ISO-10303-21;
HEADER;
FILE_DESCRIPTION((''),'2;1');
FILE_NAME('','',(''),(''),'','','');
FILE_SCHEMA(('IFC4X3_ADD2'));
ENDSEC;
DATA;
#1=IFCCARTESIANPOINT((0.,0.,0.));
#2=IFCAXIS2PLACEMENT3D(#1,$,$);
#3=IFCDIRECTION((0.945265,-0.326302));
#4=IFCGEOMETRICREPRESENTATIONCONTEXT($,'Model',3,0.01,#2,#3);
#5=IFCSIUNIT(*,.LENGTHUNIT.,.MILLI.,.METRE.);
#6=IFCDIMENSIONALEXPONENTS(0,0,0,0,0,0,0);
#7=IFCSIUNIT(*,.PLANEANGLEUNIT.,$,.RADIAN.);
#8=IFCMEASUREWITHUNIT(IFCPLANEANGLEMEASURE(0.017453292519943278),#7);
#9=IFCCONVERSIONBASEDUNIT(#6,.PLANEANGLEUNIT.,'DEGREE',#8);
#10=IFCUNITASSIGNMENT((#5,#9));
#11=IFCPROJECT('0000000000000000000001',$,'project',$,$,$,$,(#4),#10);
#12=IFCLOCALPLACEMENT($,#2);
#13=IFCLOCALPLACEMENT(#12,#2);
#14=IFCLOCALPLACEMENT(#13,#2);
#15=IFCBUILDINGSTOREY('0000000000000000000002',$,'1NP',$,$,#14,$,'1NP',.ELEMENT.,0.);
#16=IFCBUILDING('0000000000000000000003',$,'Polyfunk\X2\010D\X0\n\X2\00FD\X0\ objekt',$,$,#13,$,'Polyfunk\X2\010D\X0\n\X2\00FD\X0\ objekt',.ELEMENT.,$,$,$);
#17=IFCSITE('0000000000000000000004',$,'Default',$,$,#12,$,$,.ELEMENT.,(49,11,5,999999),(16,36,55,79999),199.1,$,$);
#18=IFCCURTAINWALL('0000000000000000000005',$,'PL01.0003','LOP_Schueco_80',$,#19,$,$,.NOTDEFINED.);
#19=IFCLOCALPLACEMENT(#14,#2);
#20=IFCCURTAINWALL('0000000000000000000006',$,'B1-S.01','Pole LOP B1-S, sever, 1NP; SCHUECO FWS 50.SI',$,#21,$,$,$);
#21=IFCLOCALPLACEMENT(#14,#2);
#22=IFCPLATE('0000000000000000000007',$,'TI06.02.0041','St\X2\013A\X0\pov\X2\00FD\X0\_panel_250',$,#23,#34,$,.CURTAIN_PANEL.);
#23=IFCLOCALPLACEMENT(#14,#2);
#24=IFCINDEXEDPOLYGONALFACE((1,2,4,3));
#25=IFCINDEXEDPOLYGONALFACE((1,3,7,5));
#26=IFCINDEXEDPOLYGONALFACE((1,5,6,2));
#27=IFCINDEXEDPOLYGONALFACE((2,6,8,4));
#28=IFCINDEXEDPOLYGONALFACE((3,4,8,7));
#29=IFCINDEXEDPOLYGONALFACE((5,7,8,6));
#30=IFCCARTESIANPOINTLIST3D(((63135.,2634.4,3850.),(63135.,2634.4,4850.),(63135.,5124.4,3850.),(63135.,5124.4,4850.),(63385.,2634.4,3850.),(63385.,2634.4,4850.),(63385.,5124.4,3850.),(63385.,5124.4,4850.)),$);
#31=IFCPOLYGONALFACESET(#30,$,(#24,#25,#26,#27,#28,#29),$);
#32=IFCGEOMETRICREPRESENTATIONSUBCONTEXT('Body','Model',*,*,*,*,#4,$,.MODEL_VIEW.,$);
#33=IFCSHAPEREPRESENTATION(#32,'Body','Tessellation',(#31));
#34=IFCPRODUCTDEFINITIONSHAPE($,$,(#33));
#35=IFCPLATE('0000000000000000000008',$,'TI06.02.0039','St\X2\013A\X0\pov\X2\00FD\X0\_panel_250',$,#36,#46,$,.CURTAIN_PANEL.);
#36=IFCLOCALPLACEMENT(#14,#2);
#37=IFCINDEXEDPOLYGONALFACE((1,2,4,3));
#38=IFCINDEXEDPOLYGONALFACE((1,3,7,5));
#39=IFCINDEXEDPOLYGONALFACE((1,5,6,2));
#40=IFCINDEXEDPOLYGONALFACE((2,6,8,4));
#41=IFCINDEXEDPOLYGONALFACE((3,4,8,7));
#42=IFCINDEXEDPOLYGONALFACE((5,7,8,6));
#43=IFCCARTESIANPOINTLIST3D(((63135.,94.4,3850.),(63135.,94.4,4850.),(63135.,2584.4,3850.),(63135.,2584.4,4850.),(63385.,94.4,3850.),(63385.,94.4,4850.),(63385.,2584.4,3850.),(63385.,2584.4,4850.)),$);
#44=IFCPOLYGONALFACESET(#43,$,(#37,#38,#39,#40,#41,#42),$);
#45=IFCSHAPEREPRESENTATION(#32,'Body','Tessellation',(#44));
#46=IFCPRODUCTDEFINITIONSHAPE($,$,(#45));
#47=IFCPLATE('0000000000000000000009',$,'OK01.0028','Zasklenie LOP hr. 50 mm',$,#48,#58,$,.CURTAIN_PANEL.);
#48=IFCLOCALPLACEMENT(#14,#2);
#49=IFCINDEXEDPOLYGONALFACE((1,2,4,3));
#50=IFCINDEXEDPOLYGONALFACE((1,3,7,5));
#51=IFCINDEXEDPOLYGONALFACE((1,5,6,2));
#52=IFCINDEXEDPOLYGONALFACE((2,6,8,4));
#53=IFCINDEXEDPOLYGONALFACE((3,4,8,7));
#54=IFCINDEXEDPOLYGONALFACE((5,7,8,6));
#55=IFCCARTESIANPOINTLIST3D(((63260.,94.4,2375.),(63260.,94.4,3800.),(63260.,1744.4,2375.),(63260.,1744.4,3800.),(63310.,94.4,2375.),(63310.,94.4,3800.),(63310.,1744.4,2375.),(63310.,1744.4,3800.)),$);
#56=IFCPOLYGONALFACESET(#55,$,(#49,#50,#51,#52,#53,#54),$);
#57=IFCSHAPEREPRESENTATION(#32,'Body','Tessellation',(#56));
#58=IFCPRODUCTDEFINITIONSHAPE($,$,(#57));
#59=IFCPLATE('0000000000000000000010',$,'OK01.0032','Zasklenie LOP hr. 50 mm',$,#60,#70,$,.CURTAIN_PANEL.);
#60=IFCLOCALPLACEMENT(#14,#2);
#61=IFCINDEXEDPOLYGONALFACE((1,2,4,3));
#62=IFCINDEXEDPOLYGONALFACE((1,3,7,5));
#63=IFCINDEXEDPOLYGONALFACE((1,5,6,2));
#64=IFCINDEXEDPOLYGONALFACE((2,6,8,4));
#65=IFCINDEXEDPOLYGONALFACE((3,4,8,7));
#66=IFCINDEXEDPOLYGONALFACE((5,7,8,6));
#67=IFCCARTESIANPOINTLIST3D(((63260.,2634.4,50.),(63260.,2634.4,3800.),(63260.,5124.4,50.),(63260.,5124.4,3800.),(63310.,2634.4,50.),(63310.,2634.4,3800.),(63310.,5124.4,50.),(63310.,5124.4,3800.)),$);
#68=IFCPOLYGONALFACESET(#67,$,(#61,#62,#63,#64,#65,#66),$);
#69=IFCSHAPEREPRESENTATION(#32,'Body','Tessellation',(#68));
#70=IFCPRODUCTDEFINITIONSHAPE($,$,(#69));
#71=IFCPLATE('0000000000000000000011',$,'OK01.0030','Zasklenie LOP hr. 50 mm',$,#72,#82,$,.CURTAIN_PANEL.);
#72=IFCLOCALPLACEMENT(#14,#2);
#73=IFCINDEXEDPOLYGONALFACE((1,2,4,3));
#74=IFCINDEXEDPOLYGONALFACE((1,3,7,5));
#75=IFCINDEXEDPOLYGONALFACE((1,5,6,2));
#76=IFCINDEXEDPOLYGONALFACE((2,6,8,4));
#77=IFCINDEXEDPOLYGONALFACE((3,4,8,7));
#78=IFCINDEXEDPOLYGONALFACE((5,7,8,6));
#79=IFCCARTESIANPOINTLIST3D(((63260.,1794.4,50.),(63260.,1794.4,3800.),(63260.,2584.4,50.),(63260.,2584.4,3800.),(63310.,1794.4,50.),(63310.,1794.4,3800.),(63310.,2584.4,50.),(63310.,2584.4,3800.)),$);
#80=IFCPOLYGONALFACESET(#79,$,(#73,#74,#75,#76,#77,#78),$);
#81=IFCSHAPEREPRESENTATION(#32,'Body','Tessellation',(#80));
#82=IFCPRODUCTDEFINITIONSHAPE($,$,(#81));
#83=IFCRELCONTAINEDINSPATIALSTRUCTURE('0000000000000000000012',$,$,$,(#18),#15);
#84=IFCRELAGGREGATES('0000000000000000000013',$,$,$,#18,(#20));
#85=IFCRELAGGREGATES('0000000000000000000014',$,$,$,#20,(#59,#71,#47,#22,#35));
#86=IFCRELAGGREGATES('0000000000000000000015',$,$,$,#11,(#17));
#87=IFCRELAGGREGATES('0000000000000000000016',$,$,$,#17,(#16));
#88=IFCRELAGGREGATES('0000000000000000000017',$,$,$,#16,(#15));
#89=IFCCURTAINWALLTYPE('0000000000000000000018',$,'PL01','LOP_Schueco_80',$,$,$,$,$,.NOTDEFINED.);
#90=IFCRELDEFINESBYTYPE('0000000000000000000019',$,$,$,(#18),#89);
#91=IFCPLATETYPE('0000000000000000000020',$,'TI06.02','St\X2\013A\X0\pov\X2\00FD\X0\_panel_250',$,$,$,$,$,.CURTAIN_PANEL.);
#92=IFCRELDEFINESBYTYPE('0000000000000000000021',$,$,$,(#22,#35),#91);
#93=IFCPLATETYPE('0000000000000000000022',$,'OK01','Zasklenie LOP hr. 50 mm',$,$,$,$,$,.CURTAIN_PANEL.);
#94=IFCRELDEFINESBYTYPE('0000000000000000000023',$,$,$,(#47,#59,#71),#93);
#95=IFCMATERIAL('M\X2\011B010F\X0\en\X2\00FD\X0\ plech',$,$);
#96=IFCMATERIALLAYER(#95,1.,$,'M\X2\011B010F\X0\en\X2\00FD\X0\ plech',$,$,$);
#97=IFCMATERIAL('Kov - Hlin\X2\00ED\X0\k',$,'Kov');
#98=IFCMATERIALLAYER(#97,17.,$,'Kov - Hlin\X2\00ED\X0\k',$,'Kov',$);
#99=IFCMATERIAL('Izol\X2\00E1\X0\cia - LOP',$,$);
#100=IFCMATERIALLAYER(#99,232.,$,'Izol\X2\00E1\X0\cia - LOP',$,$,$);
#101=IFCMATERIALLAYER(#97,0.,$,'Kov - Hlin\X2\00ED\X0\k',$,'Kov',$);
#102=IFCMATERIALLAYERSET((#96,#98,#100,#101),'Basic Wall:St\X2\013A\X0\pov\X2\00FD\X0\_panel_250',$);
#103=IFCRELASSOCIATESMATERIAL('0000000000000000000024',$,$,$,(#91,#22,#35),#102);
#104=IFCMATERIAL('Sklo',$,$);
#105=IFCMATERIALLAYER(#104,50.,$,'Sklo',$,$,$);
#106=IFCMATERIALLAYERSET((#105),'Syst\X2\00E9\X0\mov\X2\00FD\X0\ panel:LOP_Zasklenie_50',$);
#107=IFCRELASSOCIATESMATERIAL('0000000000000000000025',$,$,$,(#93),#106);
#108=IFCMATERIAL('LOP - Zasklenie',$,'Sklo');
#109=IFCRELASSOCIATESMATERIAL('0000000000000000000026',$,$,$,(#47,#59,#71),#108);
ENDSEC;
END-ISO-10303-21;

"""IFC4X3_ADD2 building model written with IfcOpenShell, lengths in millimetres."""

from ifc_helpers import new_model, entity, si_unit, converted_unit, direction, frame, frame_2d, origin, origin_2d_with_axis, place, context, subcontext, project, spatial, rectangle, extrude, source, transform, mapped, material, layer, layer_set, layer_usage, type_object, type_shapes, element, aggregate, save


model = new_model("IFC4X3_ADD2")

# Units and contexts
model_context = context("Model", 3, precision=0.01, world=origin(), true_north=direction((0.945265, -0.326302)))
body_context = subcontext(model_context, "Body", "Model", "MODEL_VIEW")
ifc_project = project(units=[si_unit("LENGTHUNIT", "METRE", prefix="MILLI"), converted_unit("PLANEANGLEUNIT", "DEGREE", entity("IfcPlaneAngleMeasure", 0.017453292519943278), si_unit("PLANEANGLEUNIT", "RADIAN"), dimensions=[0, 0, 0, 0, 0, 0, 0])], contexts=[model_context])

# Site, building, storey
site_placement = place(None, origin())
site = spatial("IfcSite", under=ifc_project, at=site_placement, Name="Default", CompositionType="ELEMENT", RefLatitude=(49, 11, 5, 999999), RefLongitude=(16, 36, 55, 79999), RefElevation=199.1)
building_placement = place(site_placement, origin())
building = spatial("IfcBuilding", under=site, at=building_placement, Name="Polyfunkčný objekt", LongName="Polyfunkčný objekt", CompositionType="ELEMENT")
storey_placement = place(building_placement, origin())
storey = spatial("IfcBuildingStorey", under=building, at=storey_placement, Name="1NP", LongName="1NP", CompositionType="ELEMENT", Elevation=0.0)

# Curtain walls, plates
curtain_wall_type = type_object("IfcCurtainWallType", Name="PL01", Description="LOP_Schueco_80", PredefinedType="NOTDEFINED")
curtain_wall_1_placement = place(storey_placement, origin())
curtain_wall_1 = element("IfcCurtainWall", 1, at=curtain_wall_1_placement, inside=storey, type_object=curtain_wall_type, Name="PL01.0003", Description="LOP_Schueco_80", PredefinedType="NOTDEFINED")
curtain_wall_2 = element("IfcCurtainWall", 2, Name="B1-S.01", Description="Pole LOP B1-S, sever, 1NP; SCHUECO FWS 50.SI")
aggregate(curtain_wall_1, [curtain_wall_2])
ifc_material_1 = material(Name="Měďený plech")
ifc_layer_1 = layer(ifc_material_1, 1.0, Name="Měďený plech")
ifc_material_2 = material(Name="Kov - Hliník", Category="Kov")
ifc_layer_2 = layer(ifc_material_2, 17.0, Name="Kov - Hliník", Category="Kov")
ifc_material_3 = material(Name="Izolácia - LOP")
ifc_layer_3 = layer(ifc_material_3, 232.0, Name="Izolácia - LOP")
ifc_layer_4 = layer(ifc_material_2, 0.0, Name="Kov - Hliník", Category="Kov")
ifc_layer_set_1 = layer_set([ifc_layer_1, ifc_layer_2, ifc_layer_3, ifc_layer_4], Name="Basic Wall:Stĺpový_panel_250")
ifc_layer_usage_1 = layer_usage(ifc_layer_set_1, "AXIS2", "NEGATIVE", 125.0)
plate_type_1 = type_object("IfcPlateType", Name="TI06.02", Description="Stĺpový_panel_250", PredefinedType="CURTAIN_PANEL", material=ifc_layer_set_1)
plate_1_placement = place(storey_placement, frame((63260.0, 5124.4, 3850.0), z_axis=(0.0, 0.0, 1.0), x_axis=(0.0, -1.0, 0.0)))
plate_1 = element("IfcPlate", 3, at=plate_1_placement, type_object=plate_type_1, material=ifc_layer_usage_1, Name="TI06.02.0041", Description="Stĺpový_panel_250", PredefinedType="CURTAIN_PANEL", context=body_context, shape_type="SweptSolid", body=[
    extrude(rectangle(XDim=250.0, YDim=2490.0, at=frame_2d((0.0, 0.0), x_axis=(1.0, 0.0))), frame((1245.0, 0.0, 0.0), z_axis=(0.0, 0.0, 1.0), x_axis=(0.0, 1.0, 0.0)), (0.0, 0.0, 1.0), 1000.0),
])
ifc_layer_usage_2 = layer_usage(ifc_layer_set_1, "AXIS2", "NEGATIVE", 125.0)
plate_2_placement = place(storey_placement, frame((63260.0, 2584.4, 3850.0), z_axis=(0.0, 0.0, 1.0), x_axis=(0.0, -1.0, 0.0)))
plate_2 = element("IfcPlate", 4, at=plate_2_placement, type_object=plate_type_1, material=ifc_layer_usage_2, Name="TI06.02.0039", Description="Stĺpový_panel_250", PredefinedType="CURTAIN_PANEL", context=body_context, shape_type="SweptSolid", body=[
    extrude(rectangle(XDim=250.0, YDim=2490.0, at=frame_2d((0.0, 0.0), x_axis=(1.0, 0.0))), frame((1245.0, 0.0, 0.0), z_axis=(0.0, 0.0, 1.0), x_axis=(0.0, 1.0, 0.0)), (0.0, 0.0, 1.0), 1000.0),
])
ifc_material_4 = material(Name="LOP - Zasklenie", Category="Sklo")
ifc_material_5 = material(Name="Sklo")
ifc_layer_5 = layer(ifc_material_5, 50.0, Name="Sklo")
ifc_layer_set_2 = layer_set([ifc_layer_5], Name="Systémový panel:LOP_Zasklenie_50")
plate_type_2 = type_object("IfcPlateType", Name="OK01", Description="Zasklenie LOP hr. 50 mm", PredefinedType="CURTAIN_PANEL", material=ifc_layer_set_2)
shared_shape_1 = source(origin(), body_context, "Body", "SweptSolid", [
    extrude(rectangle(XDim=50.0, YDim=1650.0, at=origin_2d_with_axis()), frame((0.0, 25.0, 0.0), z_axis=(0.0, 0.0, 1.0), x_axis=(0.0, 1.0, 0.0)), (0.0, 0.0, 1.0), 1425.0),
])
plate_3_placement = place(curtain_wall_1_placement, frame((63260.0, 919.4, 2375.0), z_axis=(0.0, 0.0, 1.0), x_axis=(0.0, -1.0, 0.0)))
plate_3 = element("IfcPlate", 5, at=plate_3_placement, type_object=plate_type_2, material=ifc_material_4, Name="OK01.0028", Description="Zasklenie LOP hr. 50 mm", PredefinedType="CURTAIN_PANEL", context=body_context, shape_type="MappedRepresentation", body=[
    mapped(shared_shape_1, transform((0.0, 0.0, 0.0), scale=1.0)),
])
shared_shape_2 = source(origin(), body_context, "Body", "SweptSolid", [
    extrude(rectangle(XDim=3750.0, YDim=2490.0, at=frame_2d((-141.7, 0.0), x_axis=(1.0, 0.0))), frame((0.0, 0.0, 2016.7), z_axis=(0.0, 1.0, 0.0), x_axis=(0.0, 0.0, 1.0)), (0.0, 0.0, 1.0), 50.0),
])
plate_4_placement = place(curtain_wall_1_placement, frame((63260.0, 3879.4, 50.0), z_axis=(0.0, 0.0, 1.0), x_axis=(0.0, -1.0, 0.0)))
plate_4 = element("IfcPlate", 6, at=plate_4_placement, type_object=plate_type_2, material=ifc_material_4, Name="OK01.0032", Description="Zasklenie LOP hr. 50 mm", PredefinedType="CURTAIN_PANEL", context=body_context, shape_type="MappedRepresentation", body=[
    mapped(shared_shape_2, transform((0.0, 0.0, 0.0), scale=1.0)),
])
shared_shape_3 = source(origin(), body_context, "Body", "SweptSolid", [
    extrude(rectangle(XDim=3750.0, YDim=790.0, at=frame_2d((-141.7, 0.0), x_axis=(1.0, 0.0))), frame((0.0, 0.0, 2016.7), z_axis=(0.0, 1.0, 0.0), x_axis=(0.0, 0.0, 1.0)), (0.0, 0.0, 1.0), 50.0),
])
type_shapes(plate_type_2, [shared_shape_1, shared_shape_2, shared_shape_3])
plate_5_placement = place(curtain_wall_1_placement, frame((63260.0, 2189.4, 50.0), z_axis=(0.0, 0.0, 1.0), x_axis=(0.0, -1.0, 0.0)))
plate_5 = element("IfcPlate", 7, at=plate_5_placement, type_object=plate_type_2, material=ifc_material_4, Name="OK01.0030", Description="Zasklenie LOP hr. 50 mm", PredefinedType="CURTAIN_PANEL", context=body_context, shape_type="MappedRepresentation", body=[
    mapped(shared_shape_3, transform((0.0, 0.0, 0.0), scale=1.0)),
])
aggregate(curtain_wall_2, [plate_4, plate_5, plate_3, plate_1, plate_2])

save(model, "model.ifc")
